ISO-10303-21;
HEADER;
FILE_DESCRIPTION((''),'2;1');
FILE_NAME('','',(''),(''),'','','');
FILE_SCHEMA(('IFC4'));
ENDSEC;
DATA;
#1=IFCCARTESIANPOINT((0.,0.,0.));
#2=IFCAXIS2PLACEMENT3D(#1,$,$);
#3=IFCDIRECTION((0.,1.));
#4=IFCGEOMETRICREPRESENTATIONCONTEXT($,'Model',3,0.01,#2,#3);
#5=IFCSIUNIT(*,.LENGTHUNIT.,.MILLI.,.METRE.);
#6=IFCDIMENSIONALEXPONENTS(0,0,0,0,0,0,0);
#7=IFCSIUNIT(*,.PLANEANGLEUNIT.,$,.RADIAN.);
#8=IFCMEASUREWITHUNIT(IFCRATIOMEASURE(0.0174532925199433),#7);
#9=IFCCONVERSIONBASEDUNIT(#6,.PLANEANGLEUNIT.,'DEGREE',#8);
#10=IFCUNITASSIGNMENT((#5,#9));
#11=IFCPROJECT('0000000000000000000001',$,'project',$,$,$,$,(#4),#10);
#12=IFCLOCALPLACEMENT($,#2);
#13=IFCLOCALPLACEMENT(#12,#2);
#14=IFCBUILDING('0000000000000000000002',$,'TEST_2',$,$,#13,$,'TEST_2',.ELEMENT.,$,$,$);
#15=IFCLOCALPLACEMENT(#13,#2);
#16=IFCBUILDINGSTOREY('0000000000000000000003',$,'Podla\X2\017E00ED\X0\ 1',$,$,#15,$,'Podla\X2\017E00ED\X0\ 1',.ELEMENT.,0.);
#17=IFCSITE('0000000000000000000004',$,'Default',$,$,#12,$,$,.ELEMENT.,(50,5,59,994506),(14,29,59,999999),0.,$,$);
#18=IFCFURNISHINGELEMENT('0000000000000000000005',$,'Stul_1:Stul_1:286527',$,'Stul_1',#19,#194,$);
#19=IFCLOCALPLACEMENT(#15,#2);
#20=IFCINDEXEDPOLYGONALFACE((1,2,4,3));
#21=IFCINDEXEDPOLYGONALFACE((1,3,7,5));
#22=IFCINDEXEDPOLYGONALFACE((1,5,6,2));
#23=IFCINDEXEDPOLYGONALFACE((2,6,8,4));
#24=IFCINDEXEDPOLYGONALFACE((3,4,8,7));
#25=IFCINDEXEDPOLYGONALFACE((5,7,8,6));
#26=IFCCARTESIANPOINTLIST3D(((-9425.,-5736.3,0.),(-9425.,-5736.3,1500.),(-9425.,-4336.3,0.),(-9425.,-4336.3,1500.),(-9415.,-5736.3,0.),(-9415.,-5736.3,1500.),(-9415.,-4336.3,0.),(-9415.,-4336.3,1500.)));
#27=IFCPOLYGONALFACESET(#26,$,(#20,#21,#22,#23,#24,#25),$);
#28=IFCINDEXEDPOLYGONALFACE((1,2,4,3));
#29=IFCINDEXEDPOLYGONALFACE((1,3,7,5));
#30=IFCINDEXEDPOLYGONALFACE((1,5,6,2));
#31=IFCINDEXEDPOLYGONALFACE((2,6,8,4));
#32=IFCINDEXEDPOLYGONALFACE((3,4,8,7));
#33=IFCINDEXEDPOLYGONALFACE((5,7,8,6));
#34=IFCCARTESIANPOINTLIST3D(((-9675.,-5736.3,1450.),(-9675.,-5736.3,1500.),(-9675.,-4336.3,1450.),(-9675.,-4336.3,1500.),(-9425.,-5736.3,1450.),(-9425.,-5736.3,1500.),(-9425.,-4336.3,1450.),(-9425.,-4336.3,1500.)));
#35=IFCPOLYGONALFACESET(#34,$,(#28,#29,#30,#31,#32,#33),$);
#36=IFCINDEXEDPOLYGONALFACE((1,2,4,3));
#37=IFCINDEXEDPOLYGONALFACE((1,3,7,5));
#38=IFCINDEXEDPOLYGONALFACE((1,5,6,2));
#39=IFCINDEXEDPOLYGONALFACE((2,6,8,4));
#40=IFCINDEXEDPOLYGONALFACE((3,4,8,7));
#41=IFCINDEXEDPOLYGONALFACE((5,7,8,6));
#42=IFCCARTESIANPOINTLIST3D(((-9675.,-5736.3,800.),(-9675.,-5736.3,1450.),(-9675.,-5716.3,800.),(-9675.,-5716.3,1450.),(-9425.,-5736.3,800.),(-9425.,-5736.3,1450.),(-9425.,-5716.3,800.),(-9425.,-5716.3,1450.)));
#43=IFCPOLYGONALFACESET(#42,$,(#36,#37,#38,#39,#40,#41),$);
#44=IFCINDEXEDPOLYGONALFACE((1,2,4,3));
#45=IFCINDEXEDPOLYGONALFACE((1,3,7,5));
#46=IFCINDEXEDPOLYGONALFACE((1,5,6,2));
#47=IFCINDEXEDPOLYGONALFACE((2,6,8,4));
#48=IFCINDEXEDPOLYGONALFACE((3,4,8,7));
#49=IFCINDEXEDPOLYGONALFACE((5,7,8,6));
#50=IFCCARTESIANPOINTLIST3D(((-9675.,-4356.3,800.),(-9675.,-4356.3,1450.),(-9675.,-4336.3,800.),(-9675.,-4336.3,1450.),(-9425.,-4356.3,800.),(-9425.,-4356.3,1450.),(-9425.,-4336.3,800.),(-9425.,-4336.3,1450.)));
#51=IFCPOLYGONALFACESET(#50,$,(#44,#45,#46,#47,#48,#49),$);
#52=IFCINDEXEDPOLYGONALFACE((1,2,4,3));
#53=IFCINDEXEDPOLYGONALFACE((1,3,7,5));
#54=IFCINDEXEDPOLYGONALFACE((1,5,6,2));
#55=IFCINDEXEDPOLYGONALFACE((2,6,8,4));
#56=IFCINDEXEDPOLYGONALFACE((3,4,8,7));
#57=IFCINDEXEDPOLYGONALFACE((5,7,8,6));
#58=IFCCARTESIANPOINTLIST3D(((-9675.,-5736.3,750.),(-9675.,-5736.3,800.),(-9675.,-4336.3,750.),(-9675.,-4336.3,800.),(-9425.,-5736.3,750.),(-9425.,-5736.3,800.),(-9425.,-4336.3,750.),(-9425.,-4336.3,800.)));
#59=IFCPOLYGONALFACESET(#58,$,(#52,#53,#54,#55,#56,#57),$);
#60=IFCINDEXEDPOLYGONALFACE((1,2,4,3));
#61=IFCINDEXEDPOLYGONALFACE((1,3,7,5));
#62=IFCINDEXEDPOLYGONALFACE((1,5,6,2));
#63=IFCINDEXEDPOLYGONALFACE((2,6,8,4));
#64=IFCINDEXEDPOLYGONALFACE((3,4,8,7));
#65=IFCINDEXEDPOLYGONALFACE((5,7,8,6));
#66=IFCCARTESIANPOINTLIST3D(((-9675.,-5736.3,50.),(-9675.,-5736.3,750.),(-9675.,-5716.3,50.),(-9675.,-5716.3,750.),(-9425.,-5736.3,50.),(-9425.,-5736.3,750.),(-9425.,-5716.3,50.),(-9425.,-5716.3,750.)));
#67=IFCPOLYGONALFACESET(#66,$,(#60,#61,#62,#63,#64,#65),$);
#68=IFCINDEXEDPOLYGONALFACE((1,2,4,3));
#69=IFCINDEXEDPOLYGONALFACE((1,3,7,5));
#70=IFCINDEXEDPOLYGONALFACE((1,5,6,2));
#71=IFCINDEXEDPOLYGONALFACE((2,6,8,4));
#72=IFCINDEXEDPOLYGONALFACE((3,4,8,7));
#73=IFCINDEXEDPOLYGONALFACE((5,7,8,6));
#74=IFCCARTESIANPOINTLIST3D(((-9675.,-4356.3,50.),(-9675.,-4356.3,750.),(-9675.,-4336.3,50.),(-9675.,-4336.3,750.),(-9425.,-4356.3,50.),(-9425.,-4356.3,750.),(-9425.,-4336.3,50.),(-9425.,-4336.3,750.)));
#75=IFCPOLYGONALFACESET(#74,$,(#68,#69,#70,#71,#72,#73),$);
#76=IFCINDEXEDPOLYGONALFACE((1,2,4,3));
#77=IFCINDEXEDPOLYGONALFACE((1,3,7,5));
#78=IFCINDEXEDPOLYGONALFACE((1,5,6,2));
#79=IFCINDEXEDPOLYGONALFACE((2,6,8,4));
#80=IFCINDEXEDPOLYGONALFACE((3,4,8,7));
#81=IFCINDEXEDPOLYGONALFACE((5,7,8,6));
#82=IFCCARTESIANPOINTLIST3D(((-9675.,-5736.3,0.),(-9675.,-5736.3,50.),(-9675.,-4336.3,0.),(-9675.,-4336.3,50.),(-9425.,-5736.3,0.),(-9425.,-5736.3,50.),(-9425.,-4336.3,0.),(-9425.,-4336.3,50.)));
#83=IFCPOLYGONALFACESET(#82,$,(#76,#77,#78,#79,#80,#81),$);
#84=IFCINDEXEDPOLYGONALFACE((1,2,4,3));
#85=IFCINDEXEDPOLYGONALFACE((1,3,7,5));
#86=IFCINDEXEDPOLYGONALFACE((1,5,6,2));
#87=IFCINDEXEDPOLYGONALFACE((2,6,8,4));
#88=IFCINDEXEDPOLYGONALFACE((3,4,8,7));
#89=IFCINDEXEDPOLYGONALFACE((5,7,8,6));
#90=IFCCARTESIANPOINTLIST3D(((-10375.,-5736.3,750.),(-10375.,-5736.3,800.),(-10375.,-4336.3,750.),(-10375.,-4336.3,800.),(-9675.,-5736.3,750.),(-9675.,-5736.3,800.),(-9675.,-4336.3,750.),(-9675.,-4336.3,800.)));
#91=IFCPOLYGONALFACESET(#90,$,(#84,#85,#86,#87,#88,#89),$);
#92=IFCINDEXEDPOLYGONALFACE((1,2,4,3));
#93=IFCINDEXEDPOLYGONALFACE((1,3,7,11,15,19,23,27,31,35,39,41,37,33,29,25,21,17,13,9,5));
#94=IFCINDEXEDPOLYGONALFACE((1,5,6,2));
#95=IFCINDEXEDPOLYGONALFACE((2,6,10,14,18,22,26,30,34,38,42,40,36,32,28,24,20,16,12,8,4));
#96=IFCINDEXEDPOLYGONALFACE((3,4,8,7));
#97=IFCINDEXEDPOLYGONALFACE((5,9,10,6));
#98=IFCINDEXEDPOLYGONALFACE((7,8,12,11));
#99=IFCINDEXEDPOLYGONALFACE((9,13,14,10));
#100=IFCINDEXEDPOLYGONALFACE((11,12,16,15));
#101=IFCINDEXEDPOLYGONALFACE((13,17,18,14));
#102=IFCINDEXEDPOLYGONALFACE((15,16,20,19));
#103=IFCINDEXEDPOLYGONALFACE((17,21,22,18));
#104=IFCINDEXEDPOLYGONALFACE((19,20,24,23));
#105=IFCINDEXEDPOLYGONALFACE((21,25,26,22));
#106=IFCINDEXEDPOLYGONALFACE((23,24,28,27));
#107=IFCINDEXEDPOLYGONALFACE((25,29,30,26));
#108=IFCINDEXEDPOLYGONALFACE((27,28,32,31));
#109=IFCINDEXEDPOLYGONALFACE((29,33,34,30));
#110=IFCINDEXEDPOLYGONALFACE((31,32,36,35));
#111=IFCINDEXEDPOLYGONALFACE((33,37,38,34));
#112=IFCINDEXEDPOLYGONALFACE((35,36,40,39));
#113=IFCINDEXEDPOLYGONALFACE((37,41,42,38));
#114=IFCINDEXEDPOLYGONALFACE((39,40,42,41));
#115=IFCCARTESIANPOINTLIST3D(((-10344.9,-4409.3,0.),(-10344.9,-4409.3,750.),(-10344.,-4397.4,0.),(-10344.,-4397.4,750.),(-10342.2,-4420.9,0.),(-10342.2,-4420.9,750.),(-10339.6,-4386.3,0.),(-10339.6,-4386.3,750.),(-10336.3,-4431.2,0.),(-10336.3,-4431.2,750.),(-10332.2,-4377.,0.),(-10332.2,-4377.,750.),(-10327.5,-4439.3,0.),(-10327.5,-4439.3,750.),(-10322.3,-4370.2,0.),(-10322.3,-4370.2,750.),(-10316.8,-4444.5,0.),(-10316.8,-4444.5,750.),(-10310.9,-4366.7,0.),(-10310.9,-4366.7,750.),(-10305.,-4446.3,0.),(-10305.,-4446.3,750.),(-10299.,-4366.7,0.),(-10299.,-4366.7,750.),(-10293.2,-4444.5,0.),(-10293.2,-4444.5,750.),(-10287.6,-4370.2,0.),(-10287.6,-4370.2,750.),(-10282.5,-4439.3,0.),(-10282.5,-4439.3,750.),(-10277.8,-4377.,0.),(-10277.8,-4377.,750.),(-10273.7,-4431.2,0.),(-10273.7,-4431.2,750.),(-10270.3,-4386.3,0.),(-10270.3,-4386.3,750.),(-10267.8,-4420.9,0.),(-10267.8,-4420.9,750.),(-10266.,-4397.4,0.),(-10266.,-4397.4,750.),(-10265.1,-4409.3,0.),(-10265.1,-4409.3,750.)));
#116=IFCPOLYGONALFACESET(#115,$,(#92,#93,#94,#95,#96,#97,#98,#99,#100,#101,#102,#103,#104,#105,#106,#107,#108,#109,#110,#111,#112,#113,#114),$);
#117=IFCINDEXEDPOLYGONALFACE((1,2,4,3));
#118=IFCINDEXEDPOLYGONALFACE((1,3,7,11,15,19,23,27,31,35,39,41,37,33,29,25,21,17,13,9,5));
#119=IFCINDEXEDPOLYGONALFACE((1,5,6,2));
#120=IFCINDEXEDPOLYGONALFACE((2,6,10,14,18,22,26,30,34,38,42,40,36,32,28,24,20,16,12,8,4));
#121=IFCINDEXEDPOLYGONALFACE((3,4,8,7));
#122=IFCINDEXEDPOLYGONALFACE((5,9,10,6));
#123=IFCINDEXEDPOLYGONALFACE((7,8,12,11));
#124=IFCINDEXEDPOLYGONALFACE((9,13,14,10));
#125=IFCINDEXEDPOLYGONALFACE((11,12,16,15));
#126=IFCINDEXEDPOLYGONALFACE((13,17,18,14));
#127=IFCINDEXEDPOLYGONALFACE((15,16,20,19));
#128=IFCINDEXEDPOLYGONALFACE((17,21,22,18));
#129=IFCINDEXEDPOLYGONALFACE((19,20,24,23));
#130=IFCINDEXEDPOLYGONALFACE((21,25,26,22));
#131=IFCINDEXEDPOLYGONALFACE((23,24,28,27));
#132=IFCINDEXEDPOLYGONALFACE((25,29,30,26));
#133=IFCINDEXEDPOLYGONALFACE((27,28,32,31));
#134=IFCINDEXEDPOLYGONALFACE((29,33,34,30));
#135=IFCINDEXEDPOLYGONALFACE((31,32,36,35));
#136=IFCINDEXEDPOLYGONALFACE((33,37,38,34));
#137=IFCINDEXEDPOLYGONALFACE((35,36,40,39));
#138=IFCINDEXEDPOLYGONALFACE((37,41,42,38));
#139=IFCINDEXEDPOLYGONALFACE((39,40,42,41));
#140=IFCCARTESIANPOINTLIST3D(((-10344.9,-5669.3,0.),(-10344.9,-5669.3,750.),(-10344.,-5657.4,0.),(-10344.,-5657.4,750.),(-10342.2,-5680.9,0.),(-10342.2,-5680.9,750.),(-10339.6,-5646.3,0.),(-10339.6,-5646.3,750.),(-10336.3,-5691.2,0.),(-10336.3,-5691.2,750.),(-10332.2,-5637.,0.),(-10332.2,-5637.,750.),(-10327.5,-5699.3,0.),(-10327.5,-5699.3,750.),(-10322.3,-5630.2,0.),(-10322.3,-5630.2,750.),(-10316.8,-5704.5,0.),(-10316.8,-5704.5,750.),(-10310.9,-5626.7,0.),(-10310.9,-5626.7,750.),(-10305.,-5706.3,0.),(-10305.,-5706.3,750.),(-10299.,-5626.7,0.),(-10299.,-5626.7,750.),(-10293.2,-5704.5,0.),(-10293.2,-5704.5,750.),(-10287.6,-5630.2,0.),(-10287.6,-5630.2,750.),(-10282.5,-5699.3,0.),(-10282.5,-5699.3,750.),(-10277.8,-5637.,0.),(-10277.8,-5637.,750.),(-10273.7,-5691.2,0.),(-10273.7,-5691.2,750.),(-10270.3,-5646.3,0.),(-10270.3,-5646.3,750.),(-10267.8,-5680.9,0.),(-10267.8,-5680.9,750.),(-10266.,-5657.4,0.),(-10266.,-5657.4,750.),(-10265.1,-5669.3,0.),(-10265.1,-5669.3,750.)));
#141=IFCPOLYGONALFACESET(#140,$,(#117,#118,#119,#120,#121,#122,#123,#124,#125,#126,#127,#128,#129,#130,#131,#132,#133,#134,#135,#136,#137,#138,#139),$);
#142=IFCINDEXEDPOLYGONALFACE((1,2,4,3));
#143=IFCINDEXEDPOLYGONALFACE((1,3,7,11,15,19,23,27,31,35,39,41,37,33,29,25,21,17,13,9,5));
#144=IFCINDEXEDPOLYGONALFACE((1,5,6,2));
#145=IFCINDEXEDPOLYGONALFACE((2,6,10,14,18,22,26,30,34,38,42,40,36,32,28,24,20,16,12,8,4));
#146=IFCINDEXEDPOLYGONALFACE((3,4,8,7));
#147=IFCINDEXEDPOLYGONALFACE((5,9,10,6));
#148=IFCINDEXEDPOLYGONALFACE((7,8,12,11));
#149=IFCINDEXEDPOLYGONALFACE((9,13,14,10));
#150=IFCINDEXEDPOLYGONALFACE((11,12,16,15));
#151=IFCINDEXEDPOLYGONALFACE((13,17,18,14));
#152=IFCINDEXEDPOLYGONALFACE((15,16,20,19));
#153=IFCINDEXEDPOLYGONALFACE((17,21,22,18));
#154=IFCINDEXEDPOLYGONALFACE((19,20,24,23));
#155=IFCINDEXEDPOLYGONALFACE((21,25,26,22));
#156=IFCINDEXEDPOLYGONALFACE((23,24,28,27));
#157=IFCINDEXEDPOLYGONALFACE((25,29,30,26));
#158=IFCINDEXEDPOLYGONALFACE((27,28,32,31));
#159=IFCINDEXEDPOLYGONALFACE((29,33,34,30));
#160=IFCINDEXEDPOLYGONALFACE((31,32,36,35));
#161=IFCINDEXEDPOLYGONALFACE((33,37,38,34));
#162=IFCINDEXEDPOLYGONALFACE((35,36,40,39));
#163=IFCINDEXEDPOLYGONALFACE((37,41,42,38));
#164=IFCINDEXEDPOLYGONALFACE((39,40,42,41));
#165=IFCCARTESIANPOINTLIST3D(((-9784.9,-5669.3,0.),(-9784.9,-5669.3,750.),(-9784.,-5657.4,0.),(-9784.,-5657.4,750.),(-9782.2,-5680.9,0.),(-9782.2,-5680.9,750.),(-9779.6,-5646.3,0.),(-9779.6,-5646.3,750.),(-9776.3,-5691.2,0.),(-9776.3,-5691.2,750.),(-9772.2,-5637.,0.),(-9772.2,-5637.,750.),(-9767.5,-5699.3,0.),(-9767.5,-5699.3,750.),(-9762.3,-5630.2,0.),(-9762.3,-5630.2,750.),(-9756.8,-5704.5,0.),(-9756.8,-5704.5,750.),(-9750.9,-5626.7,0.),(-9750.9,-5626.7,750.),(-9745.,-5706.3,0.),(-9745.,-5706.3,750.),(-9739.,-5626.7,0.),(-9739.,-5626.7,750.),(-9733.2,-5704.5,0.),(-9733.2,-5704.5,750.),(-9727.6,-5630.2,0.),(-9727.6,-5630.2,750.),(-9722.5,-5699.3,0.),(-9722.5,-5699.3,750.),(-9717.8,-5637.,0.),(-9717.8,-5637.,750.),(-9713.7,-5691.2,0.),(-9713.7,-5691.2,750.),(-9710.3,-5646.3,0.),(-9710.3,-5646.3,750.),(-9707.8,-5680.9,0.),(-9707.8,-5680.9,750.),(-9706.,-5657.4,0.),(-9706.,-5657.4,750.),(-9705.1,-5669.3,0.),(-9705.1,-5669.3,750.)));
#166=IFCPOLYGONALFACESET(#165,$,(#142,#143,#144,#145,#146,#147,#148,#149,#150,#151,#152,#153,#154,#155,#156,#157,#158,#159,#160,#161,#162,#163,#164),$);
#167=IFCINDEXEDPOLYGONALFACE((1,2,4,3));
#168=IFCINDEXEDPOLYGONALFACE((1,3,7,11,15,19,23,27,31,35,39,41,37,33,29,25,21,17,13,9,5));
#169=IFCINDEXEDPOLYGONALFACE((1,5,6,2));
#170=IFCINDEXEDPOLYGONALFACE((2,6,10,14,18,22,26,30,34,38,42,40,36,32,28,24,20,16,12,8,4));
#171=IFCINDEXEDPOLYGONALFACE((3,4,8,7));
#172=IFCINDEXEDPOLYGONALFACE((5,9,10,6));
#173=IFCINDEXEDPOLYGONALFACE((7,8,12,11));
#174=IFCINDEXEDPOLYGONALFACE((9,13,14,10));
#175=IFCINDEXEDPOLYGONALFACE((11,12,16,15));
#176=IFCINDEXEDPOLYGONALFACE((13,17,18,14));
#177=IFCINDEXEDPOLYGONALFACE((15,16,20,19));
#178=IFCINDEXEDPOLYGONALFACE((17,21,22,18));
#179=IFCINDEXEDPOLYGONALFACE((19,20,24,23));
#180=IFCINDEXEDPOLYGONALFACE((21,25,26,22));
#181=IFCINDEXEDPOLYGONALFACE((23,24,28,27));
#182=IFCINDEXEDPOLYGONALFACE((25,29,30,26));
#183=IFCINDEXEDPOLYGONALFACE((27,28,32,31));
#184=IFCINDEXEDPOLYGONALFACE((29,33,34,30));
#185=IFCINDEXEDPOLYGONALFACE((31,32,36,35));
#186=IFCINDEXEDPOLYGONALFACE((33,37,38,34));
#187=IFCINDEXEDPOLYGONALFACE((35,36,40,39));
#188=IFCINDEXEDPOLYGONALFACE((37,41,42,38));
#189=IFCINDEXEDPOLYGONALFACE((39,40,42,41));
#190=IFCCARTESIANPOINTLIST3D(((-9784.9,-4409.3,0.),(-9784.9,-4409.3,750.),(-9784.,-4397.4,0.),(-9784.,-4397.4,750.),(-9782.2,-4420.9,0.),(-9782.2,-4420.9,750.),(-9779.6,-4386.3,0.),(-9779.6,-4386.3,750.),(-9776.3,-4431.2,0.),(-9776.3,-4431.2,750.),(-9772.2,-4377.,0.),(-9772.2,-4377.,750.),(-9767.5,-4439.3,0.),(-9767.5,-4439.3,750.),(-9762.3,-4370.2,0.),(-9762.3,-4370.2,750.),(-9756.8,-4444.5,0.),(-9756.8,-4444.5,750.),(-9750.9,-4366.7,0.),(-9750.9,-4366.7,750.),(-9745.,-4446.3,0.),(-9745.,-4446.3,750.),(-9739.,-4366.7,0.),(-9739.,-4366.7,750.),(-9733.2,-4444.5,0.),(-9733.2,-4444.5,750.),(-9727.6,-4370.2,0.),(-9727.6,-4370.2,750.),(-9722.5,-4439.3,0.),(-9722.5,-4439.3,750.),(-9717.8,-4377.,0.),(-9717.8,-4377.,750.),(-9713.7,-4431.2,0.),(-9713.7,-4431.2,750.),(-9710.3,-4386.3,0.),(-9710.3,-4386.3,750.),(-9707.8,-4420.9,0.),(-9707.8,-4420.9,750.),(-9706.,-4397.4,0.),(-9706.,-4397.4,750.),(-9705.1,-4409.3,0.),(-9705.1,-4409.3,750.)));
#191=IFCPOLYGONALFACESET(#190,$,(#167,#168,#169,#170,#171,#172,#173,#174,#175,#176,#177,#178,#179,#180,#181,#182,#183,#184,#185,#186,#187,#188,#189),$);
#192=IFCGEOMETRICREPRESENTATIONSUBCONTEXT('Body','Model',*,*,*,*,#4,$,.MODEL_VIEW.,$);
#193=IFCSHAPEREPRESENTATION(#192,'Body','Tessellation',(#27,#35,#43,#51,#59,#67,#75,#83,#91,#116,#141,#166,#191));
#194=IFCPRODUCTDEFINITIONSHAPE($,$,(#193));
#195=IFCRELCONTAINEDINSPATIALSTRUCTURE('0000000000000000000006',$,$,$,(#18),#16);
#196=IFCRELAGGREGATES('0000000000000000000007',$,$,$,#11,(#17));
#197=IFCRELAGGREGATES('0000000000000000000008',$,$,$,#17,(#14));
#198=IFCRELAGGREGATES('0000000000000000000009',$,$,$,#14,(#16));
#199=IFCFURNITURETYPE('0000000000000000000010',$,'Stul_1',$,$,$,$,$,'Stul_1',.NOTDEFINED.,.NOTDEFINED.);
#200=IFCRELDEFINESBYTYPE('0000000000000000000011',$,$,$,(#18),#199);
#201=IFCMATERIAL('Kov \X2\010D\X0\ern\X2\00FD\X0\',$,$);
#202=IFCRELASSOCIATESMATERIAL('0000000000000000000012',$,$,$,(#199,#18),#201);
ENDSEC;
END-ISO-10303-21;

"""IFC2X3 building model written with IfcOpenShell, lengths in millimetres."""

from ifc_helpers import new_model, entity, si_unit, converted_unit, direction, frame, frame_2d, origin, origin_2d_with_axis, place, context, subcontext, project, spatial, rectangle, circle, extrude, source, transform, mapped, material, type_object, type_shapes, element, save


model = new_model("IFC2X3")

# Units and contexts
model_context = context("Model", 3, precision=0.01, world=origin(), true_north=direction((0.0, 1.0)))
body_context = subcontext(model_context, "Body", "Model", "MODEL_VIEW")
ifc_project = project(units=[si_unit("LENGTHUNIT", "METRE", prefix="MILLI"), converted_unit("PLANEANGLEUNIT", "DEGREE", entity("IfcRatioMeasure", 0.0174532925199433), si_unit("PLANEANGLEUNIT", "RADIAN"), dimensions=[0, 0, 0, 0, 0, 0, 0])], contexts=[model_context])

# Site, building, storey
site_placement = place(None, origin())
site = spatial("IfcSite", under=ifc_project, at=site_placement, Name="Default", CompositionType="ELEMENT", RefLatitude=(50, 5, 59, 994506), RefLongitude=(14, 29, 59, 999999), RefElevation=0.0)
building_placement = place(site_placement, origin())
building = spatial("IfcBuilding", under=site, at=building_placement, Name="TEST_2", LongName="TEST_2", CompositionType="ELEMENT")
storey_placement = place(building_placement, origin())
storey = spatial("IfcBuildingStorey", under=building, at=storey_placement, Name="Podlaží 1", LongName="Podlaží 1", CompositionType="ELEMENT", Elevation=0.0)

# Furnishing element
ifc_material_1 = material(Name="Kov černý")
furniture_type = type_object("IfcFurnitureType", Name="Stul_1", ElementType="Stul_1", material=ifc_material_1)
shared_shape_1 = source(origin(), body_context, "Body", "SweptSolid", [
    extrude(rectangle(XDim=1400.0, YDim=10.0, at=origin_2d_with_axis()), frame((0.0, 605.0, 0.0), z_axis=(0.0, 0.0, 1.0), x_axis=(-1.0, 0.0, 0.0)), (0.0, 0.0, 1.0), 1500.0),
    extrude(rectangle(XDim=1400.0, YDim=250.0, at=frame_2d((0.0, 0.0), x_axis=(1.0, 0.0))), frame((0.0, 475.0, 1450.0), z_axis=(0.0, 0.0, 1.0), x_axis=(-1.0, 0.0, 0.0)), (0.0, 0.0, 1.0), 50.0),
    extrude(rectangle(XDim=20.0, YDim=250.0, at=origin_2d_with_axis()), frame((690.0, 475.0, 800.0), z_axis=(0.0, 0.0, 1.0), x_axis=(-1.0, 0.0, 0.0)), (0.0, 0.0, 1.0), 650.0),
    extrude(rectangle(XDim=20.0, YDim=250.0, at=frame_2d((0.0, 0.0), x_axis=(1.0, 0.0))), frame((-690.0, 475.0, 800.0), z_axis=(0.0, 0.0, 1.0), x_axis=(-1.0, 0.0, 0.0)), (0.0, 0.0, 1.0), 650.0),
    extrude(rectangle(XDim=1400.0, YDim=250.0, at=origin_2d_with_axis()), frame((0.0, 475.0, 750.0), z_axis=(0.0, 0.0, 1.0), x_axis=(-1.0, 0.0, 0.0)), (0.0, 0.0, 1.0), 50.0),
    extrude(rectangle(XDim=20.0, YDim=250.0, at=origin_2d_with_axis()), frame((690.0, 475.0, 50.0), z_axis=(0.0, 0.0, 1.0), x_axis=(-1.0, 0.0, 0.0)), (0.0, 0.0, 1.0), 700.0),
    extrude(rectangle(XDim=20.0, YDim=250.0, at=frame_2d((0.0, 0.0), x_axis=(1.0, 0.0))), frame((-690.0, 475.0, 50.0), z_axis=(0.0, 0.0, 1.0), x_axis=(-1.0, 0.0, 0.0)), (0.0, 0.0, 1.0), 700.0),
    extrude(rectangle(XDim=1400.0, YDim=250.0, at=origin_2d_with_axis()), frame((0.0, 475.0, 0.0), z_axis=(0.0, 0.0, 1.0), x_axis=(-1.0, 0.0, 0.0)), (0.0, 0.0, 1.0), 50.0),
    extrude(rectangle(XDim=1400.0, YDim=700.0, at=origin_2d_with_axis()), frame((0.0, 0.0, 750.0), z_axis=(0.0, 0.0, 1.0), x_axis=(-1.0, 0.0, 0.0)), (0.0, 0.0, 1.0), 50.0),
    extrude(circle(Radius=40.0, at=frame_2d((0.0, 0.0), x_axis=(1.0, 0.0))), frame((-630.0, -280.0, 0.0)), (0.0, 0.0, 1.0), 750.0),
    extrude(circle(Radius=40.0, at=frame_2d((0.0, 0.0), x_axis=(1.0, 0.0))), frame((630.0, -280.0, 0.0)), (0.0, 0.0, 1.0), 750.0),
    extrude(circle(Radius=40.0, at=frame_2d((0.0, 0.0), x_axis=(1.0, 0.0))), frame((630.0, 280.0, 0.0)), (0.0, 0.0, 1.0), 750.0),
    extrude(circle(Radius=40.0, at=frame_2d((0.0, 0.0), x_axis=(1.0, 0.0))), frame((-630.0, 280.0, 0.0)), (0.0, 0.0, 1.0), 750.0),
])
type_shapes(furniture_type, [shared_shape_1])
for number, where, z_axis, x_axis, name in (
    (1, (-10025.0, -5036.3, 0.0), (0.0, 0.0, 1.0), (0.0, -1.0, 0.0), "Stul_1:Stul_1:286527"),
):
    element("IfcFurnishingElement", number, at=place(storey_placement, frame(where, z_axis=z_axis, x_axis=x_axis)), inside=storey, type_object=furniture_type, material=ifc_material_1, Name=name, ObjectType="Stul_1", context=body_context, shape_type="MappedRepresentation", body=[
        mapped(shared_shape_1, transform((0.0, 0.0, 0.0), scale=1.0)),
    ])

save(model, "model.ifc")
